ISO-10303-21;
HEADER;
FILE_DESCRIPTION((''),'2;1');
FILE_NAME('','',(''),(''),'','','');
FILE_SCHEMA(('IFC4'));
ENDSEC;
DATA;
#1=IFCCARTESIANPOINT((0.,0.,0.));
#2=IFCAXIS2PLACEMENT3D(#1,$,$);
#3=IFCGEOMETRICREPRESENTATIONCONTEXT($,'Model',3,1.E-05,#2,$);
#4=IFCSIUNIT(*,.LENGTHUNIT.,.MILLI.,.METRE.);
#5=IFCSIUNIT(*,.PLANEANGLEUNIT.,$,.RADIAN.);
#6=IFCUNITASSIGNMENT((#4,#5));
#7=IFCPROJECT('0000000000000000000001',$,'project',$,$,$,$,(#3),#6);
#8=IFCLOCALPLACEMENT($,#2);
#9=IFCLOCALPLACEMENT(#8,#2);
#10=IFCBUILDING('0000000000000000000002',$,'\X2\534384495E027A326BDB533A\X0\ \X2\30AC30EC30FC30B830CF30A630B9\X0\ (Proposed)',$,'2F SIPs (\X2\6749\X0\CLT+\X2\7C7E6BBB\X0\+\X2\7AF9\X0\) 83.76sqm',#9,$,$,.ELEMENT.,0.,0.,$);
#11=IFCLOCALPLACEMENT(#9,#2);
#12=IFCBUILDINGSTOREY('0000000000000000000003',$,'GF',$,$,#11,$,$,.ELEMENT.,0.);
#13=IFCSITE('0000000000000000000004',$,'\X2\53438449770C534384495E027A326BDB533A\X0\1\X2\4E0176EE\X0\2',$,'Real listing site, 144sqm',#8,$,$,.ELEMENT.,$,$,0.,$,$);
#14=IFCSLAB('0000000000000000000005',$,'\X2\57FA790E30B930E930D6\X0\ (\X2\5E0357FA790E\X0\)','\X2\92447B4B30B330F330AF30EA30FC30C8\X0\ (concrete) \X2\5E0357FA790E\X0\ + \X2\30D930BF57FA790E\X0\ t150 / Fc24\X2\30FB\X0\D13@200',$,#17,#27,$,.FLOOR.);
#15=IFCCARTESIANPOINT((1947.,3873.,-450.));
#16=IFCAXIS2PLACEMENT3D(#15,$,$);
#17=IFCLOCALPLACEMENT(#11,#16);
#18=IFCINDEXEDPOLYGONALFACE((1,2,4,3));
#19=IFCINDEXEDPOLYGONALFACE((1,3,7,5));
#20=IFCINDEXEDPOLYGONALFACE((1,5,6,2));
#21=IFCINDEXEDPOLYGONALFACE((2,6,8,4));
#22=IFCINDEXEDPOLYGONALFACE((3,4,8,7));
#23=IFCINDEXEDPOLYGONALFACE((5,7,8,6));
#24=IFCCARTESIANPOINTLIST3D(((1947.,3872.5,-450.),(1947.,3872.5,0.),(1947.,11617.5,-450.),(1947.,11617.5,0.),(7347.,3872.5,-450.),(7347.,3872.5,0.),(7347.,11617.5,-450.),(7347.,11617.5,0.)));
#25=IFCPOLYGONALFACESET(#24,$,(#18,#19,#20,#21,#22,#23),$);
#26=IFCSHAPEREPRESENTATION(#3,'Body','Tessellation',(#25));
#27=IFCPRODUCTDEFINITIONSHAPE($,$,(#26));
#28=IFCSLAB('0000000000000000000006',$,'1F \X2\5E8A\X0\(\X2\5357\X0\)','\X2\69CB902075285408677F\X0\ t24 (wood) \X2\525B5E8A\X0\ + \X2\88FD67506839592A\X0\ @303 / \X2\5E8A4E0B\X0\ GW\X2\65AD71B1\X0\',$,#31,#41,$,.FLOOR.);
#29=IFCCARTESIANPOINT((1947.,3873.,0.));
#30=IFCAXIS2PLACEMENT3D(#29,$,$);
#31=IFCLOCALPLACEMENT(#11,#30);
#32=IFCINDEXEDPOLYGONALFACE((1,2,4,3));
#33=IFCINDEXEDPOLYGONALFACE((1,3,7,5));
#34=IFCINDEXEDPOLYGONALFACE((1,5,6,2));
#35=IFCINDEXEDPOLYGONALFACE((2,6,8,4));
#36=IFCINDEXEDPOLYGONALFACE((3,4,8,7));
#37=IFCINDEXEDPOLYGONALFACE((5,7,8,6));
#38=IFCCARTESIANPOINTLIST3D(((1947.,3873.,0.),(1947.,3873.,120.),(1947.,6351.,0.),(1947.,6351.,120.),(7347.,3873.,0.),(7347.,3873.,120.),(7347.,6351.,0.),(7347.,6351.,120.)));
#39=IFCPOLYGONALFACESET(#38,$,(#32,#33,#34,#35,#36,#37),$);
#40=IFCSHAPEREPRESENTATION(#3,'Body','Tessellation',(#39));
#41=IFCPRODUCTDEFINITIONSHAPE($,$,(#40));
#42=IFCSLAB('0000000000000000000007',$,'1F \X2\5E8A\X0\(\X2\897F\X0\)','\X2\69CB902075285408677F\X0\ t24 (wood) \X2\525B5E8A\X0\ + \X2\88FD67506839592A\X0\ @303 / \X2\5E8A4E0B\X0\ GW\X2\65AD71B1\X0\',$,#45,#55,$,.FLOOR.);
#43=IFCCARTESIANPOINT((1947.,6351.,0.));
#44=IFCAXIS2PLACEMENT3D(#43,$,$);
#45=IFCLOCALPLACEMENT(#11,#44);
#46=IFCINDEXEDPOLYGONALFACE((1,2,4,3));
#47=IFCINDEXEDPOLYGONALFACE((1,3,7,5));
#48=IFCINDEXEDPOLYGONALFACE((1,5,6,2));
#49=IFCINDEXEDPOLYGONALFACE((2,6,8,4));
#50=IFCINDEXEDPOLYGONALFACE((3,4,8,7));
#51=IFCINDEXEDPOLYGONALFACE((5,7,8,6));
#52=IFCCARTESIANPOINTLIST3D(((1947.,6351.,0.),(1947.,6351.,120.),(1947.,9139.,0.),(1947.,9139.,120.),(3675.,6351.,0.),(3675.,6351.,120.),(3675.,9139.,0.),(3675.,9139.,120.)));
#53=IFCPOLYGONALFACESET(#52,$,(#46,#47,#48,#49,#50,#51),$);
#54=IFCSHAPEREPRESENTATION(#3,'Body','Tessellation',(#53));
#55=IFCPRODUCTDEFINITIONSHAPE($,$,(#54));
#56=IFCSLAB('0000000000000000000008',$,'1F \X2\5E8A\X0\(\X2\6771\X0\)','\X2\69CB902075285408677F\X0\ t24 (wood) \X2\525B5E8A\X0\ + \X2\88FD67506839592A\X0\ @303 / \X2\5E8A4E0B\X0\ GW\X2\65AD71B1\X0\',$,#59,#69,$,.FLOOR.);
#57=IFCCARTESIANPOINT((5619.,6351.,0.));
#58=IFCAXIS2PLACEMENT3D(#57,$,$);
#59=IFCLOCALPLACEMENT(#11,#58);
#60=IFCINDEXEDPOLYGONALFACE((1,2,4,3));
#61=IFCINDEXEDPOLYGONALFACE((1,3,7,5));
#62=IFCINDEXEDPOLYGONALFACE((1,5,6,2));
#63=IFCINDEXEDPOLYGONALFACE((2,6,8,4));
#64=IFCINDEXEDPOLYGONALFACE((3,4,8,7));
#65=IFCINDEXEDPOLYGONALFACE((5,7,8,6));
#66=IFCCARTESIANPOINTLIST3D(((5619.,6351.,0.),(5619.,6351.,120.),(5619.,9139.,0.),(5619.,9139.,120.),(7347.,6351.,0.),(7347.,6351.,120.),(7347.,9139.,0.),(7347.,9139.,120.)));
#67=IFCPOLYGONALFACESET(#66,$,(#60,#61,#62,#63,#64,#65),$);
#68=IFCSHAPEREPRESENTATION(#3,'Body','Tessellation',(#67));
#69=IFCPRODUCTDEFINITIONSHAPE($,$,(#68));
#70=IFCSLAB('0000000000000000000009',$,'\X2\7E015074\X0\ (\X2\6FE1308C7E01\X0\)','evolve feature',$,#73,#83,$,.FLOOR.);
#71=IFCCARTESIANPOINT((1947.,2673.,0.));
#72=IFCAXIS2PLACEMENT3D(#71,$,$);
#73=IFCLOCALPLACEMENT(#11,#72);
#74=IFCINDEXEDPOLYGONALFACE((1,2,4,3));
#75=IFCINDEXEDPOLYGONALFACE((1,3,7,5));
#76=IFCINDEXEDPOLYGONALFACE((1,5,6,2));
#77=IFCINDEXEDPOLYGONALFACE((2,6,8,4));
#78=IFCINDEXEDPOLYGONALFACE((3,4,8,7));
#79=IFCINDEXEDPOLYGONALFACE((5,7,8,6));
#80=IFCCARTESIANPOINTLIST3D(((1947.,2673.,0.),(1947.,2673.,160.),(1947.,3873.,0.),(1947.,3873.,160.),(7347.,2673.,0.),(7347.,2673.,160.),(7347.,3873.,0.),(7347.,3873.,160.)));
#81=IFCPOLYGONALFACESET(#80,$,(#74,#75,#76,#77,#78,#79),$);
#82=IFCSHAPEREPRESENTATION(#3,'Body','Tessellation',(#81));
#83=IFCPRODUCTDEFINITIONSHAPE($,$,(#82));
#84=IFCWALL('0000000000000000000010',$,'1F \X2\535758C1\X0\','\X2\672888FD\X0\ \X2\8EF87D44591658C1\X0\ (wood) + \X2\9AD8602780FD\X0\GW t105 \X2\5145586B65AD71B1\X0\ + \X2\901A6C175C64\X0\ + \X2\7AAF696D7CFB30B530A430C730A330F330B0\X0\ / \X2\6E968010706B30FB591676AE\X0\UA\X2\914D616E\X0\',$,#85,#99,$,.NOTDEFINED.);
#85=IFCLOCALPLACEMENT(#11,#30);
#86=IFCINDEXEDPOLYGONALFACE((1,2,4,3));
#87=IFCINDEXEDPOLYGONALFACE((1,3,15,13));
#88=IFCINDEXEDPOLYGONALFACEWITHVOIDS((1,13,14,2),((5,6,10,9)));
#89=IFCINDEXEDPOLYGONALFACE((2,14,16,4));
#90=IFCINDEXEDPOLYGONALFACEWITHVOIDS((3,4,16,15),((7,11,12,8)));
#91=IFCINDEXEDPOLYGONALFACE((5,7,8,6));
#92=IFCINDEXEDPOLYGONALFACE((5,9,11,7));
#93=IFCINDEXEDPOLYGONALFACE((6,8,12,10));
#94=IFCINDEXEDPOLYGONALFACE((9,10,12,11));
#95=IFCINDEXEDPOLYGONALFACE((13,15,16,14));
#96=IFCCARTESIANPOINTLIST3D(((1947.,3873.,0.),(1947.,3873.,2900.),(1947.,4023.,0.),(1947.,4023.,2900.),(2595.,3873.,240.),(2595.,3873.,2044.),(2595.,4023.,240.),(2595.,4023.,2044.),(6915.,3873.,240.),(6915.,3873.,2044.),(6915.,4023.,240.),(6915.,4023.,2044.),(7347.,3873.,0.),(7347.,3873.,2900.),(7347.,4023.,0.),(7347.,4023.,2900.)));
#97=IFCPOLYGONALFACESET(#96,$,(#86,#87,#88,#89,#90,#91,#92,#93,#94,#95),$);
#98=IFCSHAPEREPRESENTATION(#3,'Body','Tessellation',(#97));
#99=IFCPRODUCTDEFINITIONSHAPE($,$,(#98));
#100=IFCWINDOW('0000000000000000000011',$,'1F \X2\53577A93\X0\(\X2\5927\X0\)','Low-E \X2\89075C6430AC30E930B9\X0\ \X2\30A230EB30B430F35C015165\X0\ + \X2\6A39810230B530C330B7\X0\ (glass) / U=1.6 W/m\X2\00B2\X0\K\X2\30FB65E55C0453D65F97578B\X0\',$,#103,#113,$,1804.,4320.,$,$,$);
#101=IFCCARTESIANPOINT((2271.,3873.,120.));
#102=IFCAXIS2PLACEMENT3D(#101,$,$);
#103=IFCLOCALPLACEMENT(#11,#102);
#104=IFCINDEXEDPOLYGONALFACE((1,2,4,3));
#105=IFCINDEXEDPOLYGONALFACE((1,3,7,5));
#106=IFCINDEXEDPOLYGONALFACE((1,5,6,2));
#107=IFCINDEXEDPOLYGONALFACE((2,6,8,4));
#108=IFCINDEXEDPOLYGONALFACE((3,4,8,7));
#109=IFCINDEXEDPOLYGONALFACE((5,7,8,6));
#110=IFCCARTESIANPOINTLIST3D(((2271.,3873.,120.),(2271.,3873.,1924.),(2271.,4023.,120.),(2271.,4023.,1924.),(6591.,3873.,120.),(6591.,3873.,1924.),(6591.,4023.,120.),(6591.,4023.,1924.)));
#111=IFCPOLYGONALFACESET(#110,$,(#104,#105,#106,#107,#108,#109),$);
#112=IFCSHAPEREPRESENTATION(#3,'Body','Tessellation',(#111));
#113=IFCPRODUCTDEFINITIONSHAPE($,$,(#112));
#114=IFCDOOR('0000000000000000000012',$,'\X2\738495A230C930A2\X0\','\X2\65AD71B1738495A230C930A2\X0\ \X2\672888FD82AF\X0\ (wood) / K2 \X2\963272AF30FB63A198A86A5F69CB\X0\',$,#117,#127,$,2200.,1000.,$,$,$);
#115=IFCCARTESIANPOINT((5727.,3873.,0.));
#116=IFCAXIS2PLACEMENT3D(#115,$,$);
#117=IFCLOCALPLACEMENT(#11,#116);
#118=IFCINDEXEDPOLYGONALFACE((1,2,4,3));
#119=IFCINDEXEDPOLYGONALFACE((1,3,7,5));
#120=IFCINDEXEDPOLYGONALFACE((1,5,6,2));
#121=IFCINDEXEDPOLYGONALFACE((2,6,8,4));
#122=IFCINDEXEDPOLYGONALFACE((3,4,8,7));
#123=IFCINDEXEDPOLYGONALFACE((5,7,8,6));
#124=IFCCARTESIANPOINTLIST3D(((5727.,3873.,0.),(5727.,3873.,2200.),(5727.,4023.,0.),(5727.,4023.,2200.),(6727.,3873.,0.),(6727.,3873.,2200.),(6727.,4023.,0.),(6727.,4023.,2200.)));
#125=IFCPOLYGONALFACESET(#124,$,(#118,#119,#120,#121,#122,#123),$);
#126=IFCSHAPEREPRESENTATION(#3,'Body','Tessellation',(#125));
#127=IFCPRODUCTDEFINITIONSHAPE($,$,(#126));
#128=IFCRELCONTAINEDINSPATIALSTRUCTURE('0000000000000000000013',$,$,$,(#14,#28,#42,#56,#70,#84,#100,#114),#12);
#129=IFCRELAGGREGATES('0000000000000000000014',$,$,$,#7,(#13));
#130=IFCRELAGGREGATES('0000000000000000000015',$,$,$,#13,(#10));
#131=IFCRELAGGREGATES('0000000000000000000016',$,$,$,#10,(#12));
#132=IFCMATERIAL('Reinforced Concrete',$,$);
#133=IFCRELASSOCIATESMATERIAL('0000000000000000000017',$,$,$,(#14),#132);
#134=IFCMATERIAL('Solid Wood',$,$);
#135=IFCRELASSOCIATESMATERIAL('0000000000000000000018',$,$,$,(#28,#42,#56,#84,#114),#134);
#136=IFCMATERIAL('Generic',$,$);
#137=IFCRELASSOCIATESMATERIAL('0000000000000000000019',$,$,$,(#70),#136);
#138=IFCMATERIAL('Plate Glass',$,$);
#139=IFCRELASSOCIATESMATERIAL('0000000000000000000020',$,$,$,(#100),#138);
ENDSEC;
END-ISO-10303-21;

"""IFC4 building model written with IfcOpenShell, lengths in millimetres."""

from ifc_helpers import new_model, si_unit, frame, frame_2d, origin, place, context, project, spatial, rectangle, extrude, material, element, fill, save


model = new_model("IFC4")

# Units and contexts
model_context = context("Model", 3, precision=1e-05, world=origin())
ifc_project = project(units=[si_unit("LENGTHUNIT", "METRE", prefix="MILLI"), si_unit("PLANEANGLEUNIT", "RADIAN")], contexts=[model_context])

# Site, building, storey
site_placement = place(None, origin())
site = spatial("IfcSite", under=ifc_project, at=site_placement, Name="千葉県千葉市稲毛区1丁目2", ObjectType="Real listing site, 144sqm", CompositionType="ELEMENT", RefElevation=0.0)
building_placement = place(site_placement, origin())
building = spatial("IfcBuilding", under=site, at=building_placement, Name="千葉市稲毛区 ガレージハウス (Proposed)", ObjectType="2F SIPs (杉CLT+籾殻+竹) 83.76sqm", CompositionType="ELEMENT", ElevationOfRefHeight=0.0, ElevationOfTerrain=0.0)
storey_placement = place(building_placement, origin())
storey = spatial("IfcBuildingStorey", under=building, at=storey_placement, Name="GF", CompositionType="ELEMENT", Elevation=0.0)

# Slabs
ifc_material_1 = material(Name="Reinforced Concrete")
slab_1_placement = place(storey_placement, frame((1947.0, 3873.0, -450.0)))
element("IfcSlab", 1, at=slab_1_placement, inside=storey, material=ifc_material_1, Name="基礎スラブ (布基礎)", Description="鉄筋コンクリート (concrete) 布基礎 + ベタ基礎 t150 / Fc24・D13@200", PredefinedType="FLOOR", context=model_context, shape_type="SweptSolid", body=[
    extrude(rectangle(XDim=5400.0, YDim=7745.0, at=frame_2d((2700.0, 3872.0))), frame((1947.0, 3873.0, -450.0)), (0.0, 0.0, 1.0), 450.0),
])
ifc_material_2 = material(Name="Solid Wood")
slab_2_placement = place(storey_placement, frame((1947.0, 3873.0, 0.0)))
element("IfcSlab", 2, at=slab_2_placement, inside=storey, material=ifc_material_2, Name="1F 床(南)", Description="構造用合板 t24 (wood) 剛床 + 製材根太 @303 / 床下 GW断熱", PredefinedType="FLOOR", context=model_context, shape_type="SweptSolid", body=[
    extrude(rectangle(XDim=5400.0, YDim=2478.0, at=frame_2d((2700.0, 1239.0))), frame((1947.0, 3873.0, 0.0)), (0.0, 0.0, 1.0), 120.0),
])
slab_3_placement = place(storey_placement, frame((1947.0, 6351.0, 0.0)))
element("IfcSlab", 3, at=slab_3_placement, inside=storey, material=ifc_material_2, Name="1F 床(西)", Description="構造用合板 t24 (wood) 剛床 + 製材根太 @303 / 床下 GW断熱", PredefinedType="FLOOR", context=model_context, shape_type="SweptSolid", body=[
    extrude(rectangle(XDim=1728.0, YDim=2788.0, at=frame_2d((864.0, 1394.0))), frame((1947.0, 6351.0, 0.0)), (0.0, 0.0, 1.0), 120.0),
])
slab_4_placement = place(storey_placement, frame((5619.0, 6351.0, 0.0)))
element("IfcSlab", 4, at=slab_4_placement, inside=storey, material=ifc_material_2, Name="1F 床(東)", Description="構造用合板 t24 (wood) 剛床 + 製材根太 @303 / 床下 GW断熱", PredefinedType="FLOOR", context=model_context, shape_type="SweptSolid", body=[
    extrude(rectangle(XDim=1728.0, YDim=2788.0, at=frame_2d((864.0, 1394.0))), frame((5619.0, 6351.0, 0.0)), (0.0, 0.0, 1.0), 120.0),
])
ifc_material_3 = material(Name="Generic")
slab_5_placement = place(storey_placement, frame((1947.0, 2673.0, 0.0)))
element("IfcSlab", 5, at=slab_5_placement, inside=storey, material=ifc_material_3, Name="縁側 (濡れ縁)", Description="evolve feature", PredefinedType="FLOOR", context=model_context, shape_type="SweptSolid", body=[
    extrude(rectangle(XDim=5400.0, YDim=1200.0, at=frame_2d((2700.0, 600.0))), frame((1947.0, 2673.0, 0.0)), (0.0, 0.0, 1.0), 160.0),
])

# Wall, openings, window, door
wall_1_placement = place(storey_placement, frame((1947.0, 3873.0, 0.0)))
wall_1 = element("IfcWall", 6, at=wall_1_placement, inside=storey, material=ifc_material_2, Name="1F 南壁", Description="木製 軸組外壁 (wood) + 高性能GW t105 充填断熱 + 通気層 + 窯業系サイディング / 準耐火・外皮UA配慮", PredefinedType="NOTDEFINED", context=model_context, shape_type="SweptSolid", body=[
    extrude(rectangle(XDim=5400.0, YDim=150.0, at=frame_2d((2700.0, 75.0))), frame((1947.0, 3873.0, 0.0)), (0.0, 0.0, 1.0), 2900.0),
])
opening_1_placement = place(storey_placement, frame((2271.0, 3873.0, 120.0)))
opening_1 = element("IfcOpeningElement", 7, at=opening_1_placement, cuts=wall_1, PredefinedType="NOTDEFINED", context=model_context, shape_type="SweptSolid", body=[
    extrude(rectangle(XDim=4320.0, YDim=150.0, at=frame_2d((2160.0, 75.0))), frame((2271.0, 3873.0, 120.0)), (0.0, 0.0, 1.0), 1804.0),
])
opening_2_placement = place(storey_placement, frame((5727.0, 3873.0, 0.0)))
opening_2 = element("IfcOpeningElement", 8, at=opening_2_placement, cuts=wall_1, PredefinedType="NOTDEFINED", context=model_context, shape_type="SweptSolid", body=[
    extrude(rectangle(XDim=1000.0, YDim=150.0, at=frame_2d((500.0, 75.0))), frame((5727.0, 3873.0, 0.0)), (0.0, 0.0, 1.0), 2200.0),
])
ifc_material_4 = material(Name="Plate Glass")
window_1_placement = place(storey_placement, frame((2271.0, 3873.0, 120.0)))
window_1 = element("IfcWindow", 9, at=window_1_placement, inside=storey, material=ifc_material_4, Name="1F 南窓(大)", Description="Low-E 複層ガラス アルゴン封入 + 樹脂サッシ (glass) / U=1.6 W/m²K・日射取得型", OverallHeight=1804.0, OverallWidth=4320.0, context=model_context, shape_type="SweptSolid", body=[
    extrude(rectangle(XDim=4320.0, YDim=150.0, at=frame_2d((2160.0, 75.0))), frame((2271.0, 3873.0, 120.0)), (0.0, 0.0, 1.0), 1804.0),
])
fill(opening_1, window_1)
door_placement = place(storey_placement, frame((5727.0, 3873.0, 0.0)))
door = element("IfcDoor", 10, at=door_placement, inside=storey, material=ifc_material_2, Name="玄関ドア", Description="断熱玄関ドア 木製芯 (wood) / K2 防犯・採風機構", OverallHeight=2200.0, OverallWidth=1000.0, context=model_context, shape_type="SweptSolid", body=[
    extrude(rectangle(XDim=1000.0, YDim=150.0, at=frame_2d((500.0, 75.0))), frame((5727.0, 3873.0, 0.0)), (0.0, 0.0, 1.0), 2200.0),
])
fill(opening_2, door)

save(model, "model.ifc")
